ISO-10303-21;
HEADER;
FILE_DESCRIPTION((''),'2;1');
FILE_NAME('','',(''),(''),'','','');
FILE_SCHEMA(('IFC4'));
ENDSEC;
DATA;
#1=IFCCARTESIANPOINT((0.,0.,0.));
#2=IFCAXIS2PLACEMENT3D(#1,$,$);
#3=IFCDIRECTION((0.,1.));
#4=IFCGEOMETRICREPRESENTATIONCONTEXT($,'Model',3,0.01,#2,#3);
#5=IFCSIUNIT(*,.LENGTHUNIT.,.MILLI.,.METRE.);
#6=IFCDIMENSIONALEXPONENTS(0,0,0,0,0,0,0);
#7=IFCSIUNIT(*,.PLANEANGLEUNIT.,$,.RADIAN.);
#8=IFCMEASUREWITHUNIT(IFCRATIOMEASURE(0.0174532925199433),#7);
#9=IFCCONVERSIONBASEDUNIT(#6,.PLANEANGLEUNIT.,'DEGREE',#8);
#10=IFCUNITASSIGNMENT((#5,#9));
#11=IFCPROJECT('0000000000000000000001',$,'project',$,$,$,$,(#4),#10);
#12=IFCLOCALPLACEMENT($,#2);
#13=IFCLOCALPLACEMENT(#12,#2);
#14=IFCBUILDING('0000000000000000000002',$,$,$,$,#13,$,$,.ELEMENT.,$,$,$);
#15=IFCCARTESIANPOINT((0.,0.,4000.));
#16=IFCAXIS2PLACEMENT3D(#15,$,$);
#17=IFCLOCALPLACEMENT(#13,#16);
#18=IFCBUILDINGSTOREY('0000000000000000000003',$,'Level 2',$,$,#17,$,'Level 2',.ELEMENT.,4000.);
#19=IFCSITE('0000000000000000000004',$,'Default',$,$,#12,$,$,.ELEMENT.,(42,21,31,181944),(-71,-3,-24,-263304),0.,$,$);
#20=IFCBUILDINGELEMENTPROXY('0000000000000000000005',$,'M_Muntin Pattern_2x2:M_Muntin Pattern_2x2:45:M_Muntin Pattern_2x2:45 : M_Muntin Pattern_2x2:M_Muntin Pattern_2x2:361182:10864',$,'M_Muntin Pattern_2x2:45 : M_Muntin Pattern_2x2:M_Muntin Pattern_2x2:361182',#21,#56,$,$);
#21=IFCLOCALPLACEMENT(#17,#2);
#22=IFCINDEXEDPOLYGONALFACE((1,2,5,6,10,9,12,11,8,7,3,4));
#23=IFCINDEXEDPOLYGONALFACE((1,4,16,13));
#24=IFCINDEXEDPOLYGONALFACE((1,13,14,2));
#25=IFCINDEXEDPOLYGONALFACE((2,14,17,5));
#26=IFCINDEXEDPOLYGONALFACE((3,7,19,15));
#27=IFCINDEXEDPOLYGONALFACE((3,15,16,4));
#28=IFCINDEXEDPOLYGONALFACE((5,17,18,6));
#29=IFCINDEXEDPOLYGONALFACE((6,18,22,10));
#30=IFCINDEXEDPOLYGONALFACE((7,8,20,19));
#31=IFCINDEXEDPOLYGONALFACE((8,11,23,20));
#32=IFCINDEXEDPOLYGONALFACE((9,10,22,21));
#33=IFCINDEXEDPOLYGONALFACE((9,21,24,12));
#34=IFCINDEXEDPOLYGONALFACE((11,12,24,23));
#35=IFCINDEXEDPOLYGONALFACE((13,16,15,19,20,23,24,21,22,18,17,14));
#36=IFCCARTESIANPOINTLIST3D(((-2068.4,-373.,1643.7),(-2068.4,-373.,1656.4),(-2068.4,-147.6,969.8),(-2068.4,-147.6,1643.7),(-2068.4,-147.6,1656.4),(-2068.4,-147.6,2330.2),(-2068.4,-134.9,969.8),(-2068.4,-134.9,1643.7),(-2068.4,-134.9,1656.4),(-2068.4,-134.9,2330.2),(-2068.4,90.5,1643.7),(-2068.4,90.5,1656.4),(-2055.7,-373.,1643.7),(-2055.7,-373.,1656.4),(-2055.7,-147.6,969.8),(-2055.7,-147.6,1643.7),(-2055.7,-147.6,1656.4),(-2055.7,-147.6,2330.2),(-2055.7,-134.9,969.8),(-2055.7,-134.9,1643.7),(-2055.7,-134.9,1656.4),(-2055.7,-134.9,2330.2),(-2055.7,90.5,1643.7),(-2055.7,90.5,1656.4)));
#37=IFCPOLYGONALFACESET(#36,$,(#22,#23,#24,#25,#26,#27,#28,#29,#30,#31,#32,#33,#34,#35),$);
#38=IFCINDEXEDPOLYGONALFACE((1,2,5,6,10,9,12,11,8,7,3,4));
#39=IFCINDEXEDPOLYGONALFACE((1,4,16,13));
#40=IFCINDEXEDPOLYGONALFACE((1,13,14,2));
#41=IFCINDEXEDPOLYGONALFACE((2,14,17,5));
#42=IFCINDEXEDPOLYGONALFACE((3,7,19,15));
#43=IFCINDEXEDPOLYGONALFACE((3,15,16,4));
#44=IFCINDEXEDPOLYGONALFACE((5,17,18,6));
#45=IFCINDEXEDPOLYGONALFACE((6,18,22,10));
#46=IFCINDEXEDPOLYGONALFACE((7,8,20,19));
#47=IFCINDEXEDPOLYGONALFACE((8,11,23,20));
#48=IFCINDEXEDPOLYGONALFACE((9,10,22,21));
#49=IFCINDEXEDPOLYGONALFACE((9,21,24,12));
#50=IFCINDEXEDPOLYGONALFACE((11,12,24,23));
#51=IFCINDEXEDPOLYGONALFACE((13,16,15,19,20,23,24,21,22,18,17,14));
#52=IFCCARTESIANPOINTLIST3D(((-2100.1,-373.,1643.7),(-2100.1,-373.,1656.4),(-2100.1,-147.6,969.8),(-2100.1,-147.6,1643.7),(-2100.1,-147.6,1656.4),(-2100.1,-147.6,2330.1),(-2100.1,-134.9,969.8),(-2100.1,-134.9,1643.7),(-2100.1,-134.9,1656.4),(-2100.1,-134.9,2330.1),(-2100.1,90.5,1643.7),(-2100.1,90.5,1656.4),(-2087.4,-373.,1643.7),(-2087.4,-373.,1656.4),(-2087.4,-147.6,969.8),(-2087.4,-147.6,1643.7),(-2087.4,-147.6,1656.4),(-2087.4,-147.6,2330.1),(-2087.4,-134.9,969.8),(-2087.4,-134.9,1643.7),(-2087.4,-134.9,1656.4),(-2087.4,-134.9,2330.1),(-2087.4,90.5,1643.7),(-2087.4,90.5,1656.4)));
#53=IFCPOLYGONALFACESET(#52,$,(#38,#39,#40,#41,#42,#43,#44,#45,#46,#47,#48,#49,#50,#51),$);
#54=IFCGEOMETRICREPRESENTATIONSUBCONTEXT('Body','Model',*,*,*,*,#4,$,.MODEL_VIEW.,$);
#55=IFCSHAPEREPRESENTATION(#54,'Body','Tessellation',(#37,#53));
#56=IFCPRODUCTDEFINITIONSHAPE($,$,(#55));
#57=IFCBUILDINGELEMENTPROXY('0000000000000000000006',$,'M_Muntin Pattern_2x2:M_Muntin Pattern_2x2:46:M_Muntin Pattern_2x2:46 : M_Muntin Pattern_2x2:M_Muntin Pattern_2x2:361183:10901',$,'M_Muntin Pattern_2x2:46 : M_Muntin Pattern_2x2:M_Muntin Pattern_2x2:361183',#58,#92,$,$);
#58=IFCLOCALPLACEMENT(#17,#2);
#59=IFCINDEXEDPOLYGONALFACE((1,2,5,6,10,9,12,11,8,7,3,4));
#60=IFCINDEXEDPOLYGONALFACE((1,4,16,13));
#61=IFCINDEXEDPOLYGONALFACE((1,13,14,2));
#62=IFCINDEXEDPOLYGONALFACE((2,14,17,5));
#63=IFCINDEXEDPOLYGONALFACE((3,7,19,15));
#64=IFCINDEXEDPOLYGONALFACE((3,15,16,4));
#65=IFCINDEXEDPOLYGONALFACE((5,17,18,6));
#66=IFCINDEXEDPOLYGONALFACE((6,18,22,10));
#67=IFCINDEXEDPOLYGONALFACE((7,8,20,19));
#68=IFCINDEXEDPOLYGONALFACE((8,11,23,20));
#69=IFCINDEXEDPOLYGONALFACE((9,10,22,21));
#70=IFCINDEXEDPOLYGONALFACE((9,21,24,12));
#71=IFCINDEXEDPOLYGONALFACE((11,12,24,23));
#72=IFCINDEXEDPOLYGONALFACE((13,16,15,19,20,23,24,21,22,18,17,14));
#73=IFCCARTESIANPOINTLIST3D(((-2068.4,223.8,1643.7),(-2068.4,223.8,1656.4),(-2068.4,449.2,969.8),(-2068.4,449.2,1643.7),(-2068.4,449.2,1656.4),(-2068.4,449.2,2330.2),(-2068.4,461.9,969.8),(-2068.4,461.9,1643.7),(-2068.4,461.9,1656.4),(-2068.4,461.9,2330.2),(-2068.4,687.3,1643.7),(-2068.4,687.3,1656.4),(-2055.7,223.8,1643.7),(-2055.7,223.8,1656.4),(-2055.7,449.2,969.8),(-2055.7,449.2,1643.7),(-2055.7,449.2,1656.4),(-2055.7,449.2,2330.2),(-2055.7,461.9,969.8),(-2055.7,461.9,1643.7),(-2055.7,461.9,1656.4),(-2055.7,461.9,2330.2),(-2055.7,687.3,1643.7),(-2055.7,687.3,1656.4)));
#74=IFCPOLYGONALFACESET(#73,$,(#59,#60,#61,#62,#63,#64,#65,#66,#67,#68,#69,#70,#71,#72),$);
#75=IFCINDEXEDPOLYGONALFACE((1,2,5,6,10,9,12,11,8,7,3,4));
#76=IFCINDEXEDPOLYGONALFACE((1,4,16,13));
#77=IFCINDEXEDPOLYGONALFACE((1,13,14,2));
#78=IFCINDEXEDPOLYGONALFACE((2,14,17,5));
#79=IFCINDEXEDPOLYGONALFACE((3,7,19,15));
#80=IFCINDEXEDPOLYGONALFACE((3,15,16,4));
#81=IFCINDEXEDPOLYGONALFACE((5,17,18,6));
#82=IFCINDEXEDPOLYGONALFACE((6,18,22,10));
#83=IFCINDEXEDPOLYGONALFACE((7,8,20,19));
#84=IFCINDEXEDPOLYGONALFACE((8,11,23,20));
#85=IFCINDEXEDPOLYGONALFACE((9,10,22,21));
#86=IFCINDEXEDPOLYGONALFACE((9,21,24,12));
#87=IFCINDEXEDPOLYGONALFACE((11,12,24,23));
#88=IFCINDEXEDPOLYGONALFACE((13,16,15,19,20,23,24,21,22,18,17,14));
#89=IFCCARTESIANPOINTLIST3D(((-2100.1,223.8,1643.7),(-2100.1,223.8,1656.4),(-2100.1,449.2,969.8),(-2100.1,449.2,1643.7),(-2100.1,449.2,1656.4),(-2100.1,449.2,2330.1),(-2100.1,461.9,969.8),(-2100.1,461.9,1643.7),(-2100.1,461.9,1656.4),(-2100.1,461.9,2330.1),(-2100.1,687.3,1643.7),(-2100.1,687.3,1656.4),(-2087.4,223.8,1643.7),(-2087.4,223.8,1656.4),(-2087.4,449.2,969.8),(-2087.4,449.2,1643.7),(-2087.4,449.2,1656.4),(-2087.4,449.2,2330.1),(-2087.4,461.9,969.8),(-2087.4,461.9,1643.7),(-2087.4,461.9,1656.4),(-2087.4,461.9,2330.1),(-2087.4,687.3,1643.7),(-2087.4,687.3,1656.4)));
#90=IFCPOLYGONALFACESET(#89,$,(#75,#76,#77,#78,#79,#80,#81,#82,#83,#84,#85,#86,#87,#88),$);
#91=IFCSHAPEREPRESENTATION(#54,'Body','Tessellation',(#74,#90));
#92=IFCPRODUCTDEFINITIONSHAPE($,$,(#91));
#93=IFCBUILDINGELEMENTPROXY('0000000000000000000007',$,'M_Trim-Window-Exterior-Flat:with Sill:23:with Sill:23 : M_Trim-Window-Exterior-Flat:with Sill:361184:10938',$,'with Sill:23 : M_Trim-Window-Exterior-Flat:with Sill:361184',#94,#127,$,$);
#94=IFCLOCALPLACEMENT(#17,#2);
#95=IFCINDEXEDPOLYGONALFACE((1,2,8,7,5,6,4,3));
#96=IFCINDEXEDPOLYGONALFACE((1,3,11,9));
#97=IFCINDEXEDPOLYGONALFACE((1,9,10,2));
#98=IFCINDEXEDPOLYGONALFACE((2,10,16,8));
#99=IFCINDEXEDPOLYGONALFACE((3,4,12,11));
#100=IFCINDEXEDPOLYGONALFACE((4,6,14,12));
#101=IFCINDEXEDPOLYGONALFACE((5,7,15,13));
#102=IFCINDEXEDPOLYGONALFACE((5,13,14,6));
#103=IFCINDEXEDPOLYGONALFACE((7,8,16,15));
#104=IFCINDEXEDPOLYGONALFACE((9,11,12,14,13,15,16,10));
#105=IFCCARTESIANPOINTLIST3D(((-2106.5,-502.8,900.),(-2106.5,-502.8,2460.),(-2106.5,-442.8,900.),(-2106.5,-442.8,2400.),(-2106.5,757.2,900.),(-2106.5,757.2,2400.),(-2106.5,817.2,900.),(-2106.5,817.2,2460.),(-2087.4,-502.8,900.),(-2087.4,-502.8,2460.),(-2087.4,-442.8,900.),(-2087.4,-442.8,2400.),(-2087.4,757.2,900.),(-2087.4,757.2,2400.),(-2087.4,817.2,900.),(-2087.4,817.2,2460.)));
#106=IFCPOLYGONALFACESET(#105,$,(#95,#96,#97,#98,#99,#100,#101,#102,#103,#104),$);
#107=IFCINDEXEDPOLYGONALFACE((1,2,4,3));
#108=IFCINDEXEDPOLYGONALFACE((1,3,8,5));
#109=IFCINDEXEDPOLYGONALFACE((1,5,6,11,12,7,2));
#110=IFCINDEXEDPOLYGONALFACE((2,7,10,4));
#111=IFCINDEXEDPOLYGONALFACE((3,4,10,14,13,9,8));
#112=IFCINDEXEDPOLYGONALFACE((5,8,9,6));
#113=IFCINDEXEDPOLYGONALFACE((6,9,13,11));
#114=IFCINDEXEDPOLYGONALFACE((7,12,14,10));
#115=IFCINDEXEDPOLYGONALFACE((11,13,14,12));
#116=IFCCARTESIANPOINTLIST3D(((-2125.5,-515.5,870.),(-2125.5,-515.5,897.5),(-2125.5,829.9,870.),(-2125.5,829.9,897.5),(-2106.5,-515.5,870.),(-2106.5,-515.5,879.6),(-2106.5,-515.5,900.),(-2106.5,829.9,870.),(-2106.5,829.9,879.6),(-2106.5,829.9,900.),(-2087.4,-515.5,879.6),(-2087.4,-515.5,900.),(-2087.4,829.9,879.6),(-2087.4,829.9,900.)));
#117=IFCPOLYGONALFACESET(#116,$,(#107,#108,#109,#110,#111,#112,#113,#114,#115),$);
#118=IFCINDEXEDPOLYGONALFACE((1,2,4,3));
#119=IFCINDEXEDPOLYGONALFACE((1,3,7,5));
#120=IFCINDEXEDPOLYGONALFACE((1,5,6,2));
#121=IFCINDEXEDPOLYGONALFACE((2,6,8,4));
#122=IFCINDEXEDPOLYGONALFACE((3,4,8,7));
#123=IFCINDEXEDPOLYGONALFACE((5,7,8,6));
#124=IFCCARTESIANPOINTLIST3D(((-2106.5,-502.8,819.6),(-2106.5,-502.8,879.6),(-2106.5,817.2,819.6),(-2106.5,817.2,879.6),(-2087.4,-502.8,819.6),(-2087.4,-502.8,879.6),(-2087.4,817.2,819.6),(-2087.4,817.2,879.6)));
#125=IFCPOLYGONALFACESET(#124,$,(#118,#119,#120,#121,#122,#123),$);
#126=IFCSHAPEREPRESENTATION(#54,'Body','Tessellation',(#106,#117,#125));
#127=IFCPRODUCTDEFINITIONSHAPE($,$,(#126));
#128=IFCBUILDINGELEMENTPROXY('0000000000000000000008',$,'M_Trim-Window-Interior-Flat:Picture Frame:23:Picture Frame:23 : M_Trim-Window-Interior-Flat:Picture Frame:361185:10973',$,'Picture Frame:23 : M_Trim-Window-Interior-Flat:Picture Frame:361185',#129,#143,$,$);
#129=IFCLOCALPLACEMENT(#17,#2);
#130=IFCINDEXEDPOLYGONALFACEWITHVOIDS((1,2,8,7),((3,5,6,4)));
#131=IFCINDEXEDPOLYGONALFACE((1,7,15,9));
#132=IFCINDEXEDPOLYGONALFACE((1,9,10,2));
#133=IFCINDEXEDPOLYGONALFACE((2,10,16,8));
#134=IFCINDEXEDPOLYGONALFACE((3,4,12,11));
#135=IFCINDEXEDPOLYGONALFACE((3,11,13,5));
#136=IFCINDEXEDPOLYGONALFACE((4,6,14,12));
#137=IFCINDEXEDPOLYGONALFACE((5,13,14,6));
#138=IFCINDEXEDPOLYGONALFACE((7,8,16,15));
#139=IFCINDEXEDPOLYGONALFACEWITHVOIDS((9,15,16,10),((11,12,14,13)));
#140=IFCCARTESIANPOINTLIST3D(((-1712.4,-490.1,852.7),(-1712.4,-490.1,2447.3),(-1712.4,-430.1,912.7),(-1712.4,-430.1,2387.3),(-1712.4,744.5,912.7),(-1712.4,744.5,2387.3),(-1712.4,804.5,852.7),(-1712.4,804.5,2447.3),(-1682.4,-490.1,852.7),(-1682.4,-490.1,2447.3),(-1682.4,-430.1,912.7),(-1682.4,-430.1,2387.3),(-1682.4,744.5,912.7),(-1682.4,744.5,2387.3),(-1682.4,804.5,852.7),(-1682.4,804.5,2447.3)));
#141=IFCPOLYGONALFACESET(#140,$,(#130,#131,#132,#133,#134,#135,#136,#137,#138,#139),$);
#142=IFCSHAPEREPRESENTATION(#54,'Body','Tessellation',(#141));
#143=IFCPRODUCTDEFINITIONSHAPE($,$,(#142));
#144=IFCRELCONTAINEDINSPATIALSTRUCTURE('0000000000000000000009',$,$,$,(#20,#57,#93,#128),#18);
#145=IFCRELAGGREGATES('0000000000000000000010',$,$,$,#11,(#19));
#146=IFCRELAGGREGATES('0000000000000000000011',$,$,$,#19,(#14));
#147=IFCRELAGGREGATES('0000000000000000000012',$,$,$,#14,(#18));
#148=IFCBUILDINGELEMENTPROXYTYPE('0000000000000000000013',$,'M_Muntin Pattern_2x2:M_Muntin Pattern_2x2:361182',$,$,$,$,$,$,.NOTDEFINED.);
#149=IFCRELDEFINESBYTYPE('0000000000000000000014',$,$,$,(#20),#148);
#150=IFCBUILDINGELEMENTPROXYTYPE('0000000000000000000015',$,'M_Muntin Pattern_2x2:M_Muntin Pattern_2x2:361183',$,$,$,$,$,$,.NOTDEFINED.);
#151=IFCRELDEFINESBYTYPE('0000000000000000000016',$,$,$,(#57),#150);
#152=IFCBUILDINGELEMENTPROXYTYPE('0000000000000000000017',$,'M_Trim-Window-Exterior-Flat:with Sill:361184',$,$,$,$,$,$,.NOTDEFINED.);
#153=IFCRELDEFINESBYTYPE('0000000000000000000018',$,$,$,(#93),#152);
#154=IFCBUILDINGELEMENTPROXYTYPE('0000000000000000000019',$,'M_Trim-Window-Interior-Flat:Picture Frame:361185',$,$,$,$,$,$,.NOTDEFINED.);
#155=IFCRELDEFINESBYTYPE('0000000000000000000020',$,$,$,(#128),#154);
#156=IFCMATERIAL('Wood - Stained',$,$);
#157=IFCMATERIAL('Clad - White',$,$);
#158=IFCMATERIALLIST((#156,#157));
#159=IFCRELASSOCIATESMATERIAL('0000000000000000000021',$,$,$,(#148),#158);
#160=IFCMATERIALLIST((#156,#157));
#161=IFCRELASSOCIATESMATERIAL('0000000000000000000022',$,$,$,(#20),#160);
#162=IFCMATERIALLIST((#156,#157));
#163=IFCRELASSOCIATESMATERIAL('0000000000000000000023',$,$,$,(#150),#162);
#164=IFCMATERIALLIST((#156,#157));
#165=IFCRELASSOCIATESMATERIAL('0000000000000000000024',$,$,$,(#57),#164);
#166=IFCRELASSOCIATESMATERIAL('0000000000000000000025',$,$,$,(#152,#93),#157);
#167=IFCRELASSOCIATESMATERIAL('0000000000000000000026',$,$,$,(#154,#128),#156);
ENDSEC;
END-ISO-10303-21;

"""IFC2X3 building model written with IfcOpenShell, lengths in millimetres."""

from ifc_helpers import new_model, entity, si_unit, converted_unit, direction, frame, origin, origin_2d_with_axis, place, context, subcontext, project, spatial, polyline, rectangle, outline, extrude, source, transform, mapped, material, material_list, type_object, type_shapes, element, save


model = new_model("IFC2X3")

# Units and contexts
model_context = context("Model", 3, precision=0.01, world=origin(), true_north=direction((0.0, 1.0)))
body_context = subcontext(model_context, "Body", "Model", "MODEL_VIEW")
ifc_project = project(units=[si_unit("LENGTHUNIT", "METRE", prefix="MILLI"), converted_unit("PLANEANGLEUNIT", "DEGREE", entity("IfcRatioMeasure", 0.0174532925199433), si_unit("PLANEANGLEUNIT", "RADIAN"), dimensions=[0, 0, 0, 0, 0, 0, 0])], contexts=[model_context])

# Site, building, storey
site_placement = place(None, origin())
site = spatial("IfcSite", under=ifc_project, at=site_placement, Name="Default", CompositionType="ELEMENT", RefLatitude=(42, 21, 31, 181944), RefLongitude=(-71, -3, -24, -263304), RefElevation=0.0)
building_placement = place(site_placement, origin())
building = spatial("IfcBuilding", under=site, at=building_placement, CompositionType="ELEMENT")
storey_placement = place(building_placement, frame((0.0, 0.0, 4000.0)))
storey = spatial("IfcBuildingStorey", under=building, at=storey_placement, Name="Level 2", LongName="Level 2", CompositionType="ELEMENT", Elevation=4000.0)

# Building element proxies
ifc_material_1 = material(Name="Wood - Stained")
ifc_material_2 = material(Name="Clad - White")
ifc_material_list_1 = material_list([ifc_material_1, ifc_material_2])
ifc_material_list_2 = material_list([ifc_material_1, ifc_material_2])
building_element_proxy_type_1 = type_object("IfcBuildingElementProxyType", Name="M_Muntin Pattern_2x2:M_Muntin Pattern_2x2:361182", PredefinedType="NOTDEFINED", material=ifc_material_list_2)
shared_shape_1 = source(origin(), body_context, "Body", "SweptSolid", [
    extrude(outline(polyline([(-680.2, 6.4), (-680.2, -6.3), (-6.4, -6.3), (-6.4, -231.7), (6.3, -231.7), (6.3, -6.3), (680.2, -6.3), (680.2, 6.4), (6.3, 6.4), (6.3, 231.7), (-6.4, 231.7), (-6.4, 6.4), (-680.2, 6.4)])), frame((-2068.4, -141.3, 5650.0), z_axis=(-1.0, 0.0, 0.0), x_axis=(0.0, 0.0, -1.0)), (0.0, 0.0, -1.0), 12.7),
    extrude(outline(polyline([(-680.1, 6.4), (-680.1, -6.3), (-6.4, -6.3), (-6.4, -231.7), (6.3, -231.7), (6.3, -6.3), (680.2, -6.3), (680.2, 6.4), (6.3, 6.4), (6.3, 231.7), (-6.4, 231.7), (-6.4, 6.4), (-680.1, 6.4)])), frame((-2100.1, -141.3, 5650.0), z_axis=(-1.0, 0.0, 0.0), x_axis=(0.0, 0.0, -1.0)), (0.0, 0.0, -1.0), 12.7),
])
type_shapes(building_element_proxy_type_1, [shared_shape_1])
proxy_1_placement = place(storey_placement, frame((0.0, 0.0, -4000.0)))
element("IfcBuildingElementProxy", 1, at=proxy_1_placement, inside=storey, type_object=building_element_proxy_type_1, material=ifc_material_list_1, Name="M_Muntin Pattern_2x2:M_Muntin Pattern_2x2:45:M_Muntin Pattern_2x2:45 : M_Muntin Pattern_2x2:M_Muntin Pattern_2x2:361182:10864", ObjectType="M_Muntin Pattern_2x2:45 : M_Muntin Pattern_2x2:M_Muntin Pattern_2x2:361182", context=body_context, shape_type="MappedRepresentation", body=[
    mapped(shared_shape_1, transform((0.0, 0.0, 0.0), scale=1.0)),
])
ifc_material_list_3 = material_list([ifc_material_1, ifc_material_2])
ifc_material_list_4 = material_list([ifc_material_1, ifc_material_2])
building_element_proxy_type_2 = type_object("IfcBuildingElementProxyType", Name="M_Muntin Pattern_2x2:M_Muntin Pattern_2x2:361183", PredefinedType="NOTDEFINED", material=ifc_material_list_4)
shared_shape_2 = source(origin(), body_context, "Body", "SweptSolid", [
    extrude(outline(polyline([(-6.4, -680.1), (6.3, -680.1), (6.3, -6.4), (231.7, -6.4), (231.7, 6.3), (6.3, 6.3), (6.3, 680.2), (-6.4, 680.2), (-6.4, 6.3), (-231.7, 6.3), (-231.7, -6.4), (-6.4, -6.4), (-6.4, -680.1)])), frame((-2068.4, 455.6, 5650.0), z_axis=(1.0, 0.0, 0.0), x_axis=(0.0, -1.0, 0.0)), (0.0, 0.0, 1.0), 12.7),
    extrude(outline(polyline([(-6.4, -680.1), (6.3, -680.1), (6.3, -6.4), (231.7, -6.4), (231.7, 6.3), (6.3, 6.3), (6.3, 680.2), (-6.4, 680.2), (-6.4, 6.3), (-231.7, 6.3), (-231.7, -6.4), (-6.4, -6.4), (-6.4, -680.1)])), frame((-2100.1, 455.6, 5650.0), z_axis=(1.0, 0.0, 0.0), x_axis=(0.0, -1.0, 0.0)), (0.0, 0.0, 1.0), 12.7),
])
type_shapes(building_element_proxy_type_2, [shared_shape_2])
proxy_2_placement = place(storey_placement, frame((0.0, 0.0, -4000.0)))
element("IfcBuildingElementProxy", 2, at=proxy_2_placement, inside=storey, type_object=building_element_proxy_type_2, material=ifc_material_list_3, Name="M_Muntin Pattern_2x2:M_Muntin Pattern_2x2:46:M_Muntin Pattern_2x2:46 : M_Muntin Pattern_2x2:M_Muntin Pattern_2x2:361183:10901", ObjectType="M_Muntin Pattern_2x2:46 : M_Muntin Pattern_2x2:M_Muntin Pattern_2x2:361183", context=body_context, shape_type="MappedRepresentation", body=[
    mapped(shared_shape_2, transform((0.0, 0.0, 0.0), scale=1.0)),
])
building_element_proxy_type_3 = type_object("IfcBuildingElementProxyType", Name="M_Trim-Window-Exterior-Flat:with Sill:361184", PredefinedType="NOTDEFINED", material=ifc_material_2)
shared_shape_3 = source(origin(), body_context, "Body", "SweptSolid", [
    extrude(outline(polyline([(-765.0, -660.0), (795.0, -660.0), (795.0, 660.0), (-765.0, 660.0), (-765.0, 600.0), (735.0, 600.0), (735.0, -600.0), (-765.0, -600.0), (-765.0, -660.0)])), frame((-2106.5, 157.2, 5665.0), z_axis=(1.0, 0.0, 0.0), x_axis=(0.0, 0.0, 1.0)), (0.0, 0.0, 1.0), 19.1),
    extrude(outline(polyline([(0.0, -15.2), (19.0, -15.2), (19.0, 12.3), (0.0, 14.8), (-19.0, 14.8), (-19.0, -5.7), (0.0, -5.7), (0.0, -15.2)])), frame((-2106.5, -515.5, 4885.2), z_axis=(0.0, 1.0, 0.0), x_axis=(-1.0, 0.0, 0.0)), (0.0, 0.0, 1.0), 1345.4),
    extrude(rectangle(XDim=19.1, YDim=1320.0, at=origin_2d_with_axis()), frame((-2097.0, 157.2, 4819.6)), (0.0, 0.0, 1.0), 60.0),
])
type_shapes(building_element_proxy_type_3, [shared_shape_3])
proxy_3_placement = place(storey_placement, frame((0.0, 0.0, -4000.0)))
element("IfcBuildingElementProxy", 3, at=proxy_3_placement, inside=storey, type_object=building_element_proxy_type_3, material=ifc_material_2, Name="M_Trim-Window-Exterior-Flat:with Sill:23:with Sill:23 : M_Trim-Window-Exterior-Flat:with Sill:361184:10938", ObjectType="with Sill:23 : M_Trim-Window-Exterior-Flat:with Sill:361184", context=body_context, shape_type="MappedRepresentation", body=[
    mapped(shared_shape_3, transform((0.0, 0.0, 0.0), scale=1.0)),
])
building_element_proxy_type_4 = type_object("IfcBuildingElementProxyType", Name="M_Trim-Window-Interior-Flat:Picture Frame:361185", PredefinedType="NOTDEFINED", material=ifc_material_1)
shared_shape_4 = source(origin(), body_context, "Body", "SweptSolid", [
    extrude(outline(polyline([(-797.3, -647.3), (797.3, -647.3), (797.3, 647.3), (-797.3, 647.3), (-797.3, -647.3)]), holes=[polyline([(737.3, 587.3), (737.3, -587.3), (-737.3, -587.3), (-737.3, 587.3), (737.3, 587.3)])]), frame((-1712.4, 157.2, 5650.0), z_axis=(1.0, 0.0, 0.0), x_axis=(0.0, 0.0, -1.0)), (0.0, 0.0, 1.0), 30.0),
])
type_shapes(building_element_proxy_type_4, [shared_shape_4])
proxy_4_placement = place(storey_placement, frame((0.0, 0.0, -4000.0)))
element("IfcBuildingElementProxy", 4, at=proxy_4_placement, inside=storey, type_object=building_element_proxy_type_4, material=ifc_material_1, Name="M_Trim-Window-Interior-Flat:Picture Frame:23:Picture Frame:23 : M_Trim-Window-Interior-Flat:Picture Frame:361185:10973", ObjectType="Picture Frame:23 : M_Trim-Window-Interior-Flat:Picture Frame:361185", context=body_context, shape_type="MappedRepresentation", body=[
    mapped(shared_shape_4, transform((0.0, 0.0, 0.0), scale=1.0)),
])

save(model, "model.ifc")
